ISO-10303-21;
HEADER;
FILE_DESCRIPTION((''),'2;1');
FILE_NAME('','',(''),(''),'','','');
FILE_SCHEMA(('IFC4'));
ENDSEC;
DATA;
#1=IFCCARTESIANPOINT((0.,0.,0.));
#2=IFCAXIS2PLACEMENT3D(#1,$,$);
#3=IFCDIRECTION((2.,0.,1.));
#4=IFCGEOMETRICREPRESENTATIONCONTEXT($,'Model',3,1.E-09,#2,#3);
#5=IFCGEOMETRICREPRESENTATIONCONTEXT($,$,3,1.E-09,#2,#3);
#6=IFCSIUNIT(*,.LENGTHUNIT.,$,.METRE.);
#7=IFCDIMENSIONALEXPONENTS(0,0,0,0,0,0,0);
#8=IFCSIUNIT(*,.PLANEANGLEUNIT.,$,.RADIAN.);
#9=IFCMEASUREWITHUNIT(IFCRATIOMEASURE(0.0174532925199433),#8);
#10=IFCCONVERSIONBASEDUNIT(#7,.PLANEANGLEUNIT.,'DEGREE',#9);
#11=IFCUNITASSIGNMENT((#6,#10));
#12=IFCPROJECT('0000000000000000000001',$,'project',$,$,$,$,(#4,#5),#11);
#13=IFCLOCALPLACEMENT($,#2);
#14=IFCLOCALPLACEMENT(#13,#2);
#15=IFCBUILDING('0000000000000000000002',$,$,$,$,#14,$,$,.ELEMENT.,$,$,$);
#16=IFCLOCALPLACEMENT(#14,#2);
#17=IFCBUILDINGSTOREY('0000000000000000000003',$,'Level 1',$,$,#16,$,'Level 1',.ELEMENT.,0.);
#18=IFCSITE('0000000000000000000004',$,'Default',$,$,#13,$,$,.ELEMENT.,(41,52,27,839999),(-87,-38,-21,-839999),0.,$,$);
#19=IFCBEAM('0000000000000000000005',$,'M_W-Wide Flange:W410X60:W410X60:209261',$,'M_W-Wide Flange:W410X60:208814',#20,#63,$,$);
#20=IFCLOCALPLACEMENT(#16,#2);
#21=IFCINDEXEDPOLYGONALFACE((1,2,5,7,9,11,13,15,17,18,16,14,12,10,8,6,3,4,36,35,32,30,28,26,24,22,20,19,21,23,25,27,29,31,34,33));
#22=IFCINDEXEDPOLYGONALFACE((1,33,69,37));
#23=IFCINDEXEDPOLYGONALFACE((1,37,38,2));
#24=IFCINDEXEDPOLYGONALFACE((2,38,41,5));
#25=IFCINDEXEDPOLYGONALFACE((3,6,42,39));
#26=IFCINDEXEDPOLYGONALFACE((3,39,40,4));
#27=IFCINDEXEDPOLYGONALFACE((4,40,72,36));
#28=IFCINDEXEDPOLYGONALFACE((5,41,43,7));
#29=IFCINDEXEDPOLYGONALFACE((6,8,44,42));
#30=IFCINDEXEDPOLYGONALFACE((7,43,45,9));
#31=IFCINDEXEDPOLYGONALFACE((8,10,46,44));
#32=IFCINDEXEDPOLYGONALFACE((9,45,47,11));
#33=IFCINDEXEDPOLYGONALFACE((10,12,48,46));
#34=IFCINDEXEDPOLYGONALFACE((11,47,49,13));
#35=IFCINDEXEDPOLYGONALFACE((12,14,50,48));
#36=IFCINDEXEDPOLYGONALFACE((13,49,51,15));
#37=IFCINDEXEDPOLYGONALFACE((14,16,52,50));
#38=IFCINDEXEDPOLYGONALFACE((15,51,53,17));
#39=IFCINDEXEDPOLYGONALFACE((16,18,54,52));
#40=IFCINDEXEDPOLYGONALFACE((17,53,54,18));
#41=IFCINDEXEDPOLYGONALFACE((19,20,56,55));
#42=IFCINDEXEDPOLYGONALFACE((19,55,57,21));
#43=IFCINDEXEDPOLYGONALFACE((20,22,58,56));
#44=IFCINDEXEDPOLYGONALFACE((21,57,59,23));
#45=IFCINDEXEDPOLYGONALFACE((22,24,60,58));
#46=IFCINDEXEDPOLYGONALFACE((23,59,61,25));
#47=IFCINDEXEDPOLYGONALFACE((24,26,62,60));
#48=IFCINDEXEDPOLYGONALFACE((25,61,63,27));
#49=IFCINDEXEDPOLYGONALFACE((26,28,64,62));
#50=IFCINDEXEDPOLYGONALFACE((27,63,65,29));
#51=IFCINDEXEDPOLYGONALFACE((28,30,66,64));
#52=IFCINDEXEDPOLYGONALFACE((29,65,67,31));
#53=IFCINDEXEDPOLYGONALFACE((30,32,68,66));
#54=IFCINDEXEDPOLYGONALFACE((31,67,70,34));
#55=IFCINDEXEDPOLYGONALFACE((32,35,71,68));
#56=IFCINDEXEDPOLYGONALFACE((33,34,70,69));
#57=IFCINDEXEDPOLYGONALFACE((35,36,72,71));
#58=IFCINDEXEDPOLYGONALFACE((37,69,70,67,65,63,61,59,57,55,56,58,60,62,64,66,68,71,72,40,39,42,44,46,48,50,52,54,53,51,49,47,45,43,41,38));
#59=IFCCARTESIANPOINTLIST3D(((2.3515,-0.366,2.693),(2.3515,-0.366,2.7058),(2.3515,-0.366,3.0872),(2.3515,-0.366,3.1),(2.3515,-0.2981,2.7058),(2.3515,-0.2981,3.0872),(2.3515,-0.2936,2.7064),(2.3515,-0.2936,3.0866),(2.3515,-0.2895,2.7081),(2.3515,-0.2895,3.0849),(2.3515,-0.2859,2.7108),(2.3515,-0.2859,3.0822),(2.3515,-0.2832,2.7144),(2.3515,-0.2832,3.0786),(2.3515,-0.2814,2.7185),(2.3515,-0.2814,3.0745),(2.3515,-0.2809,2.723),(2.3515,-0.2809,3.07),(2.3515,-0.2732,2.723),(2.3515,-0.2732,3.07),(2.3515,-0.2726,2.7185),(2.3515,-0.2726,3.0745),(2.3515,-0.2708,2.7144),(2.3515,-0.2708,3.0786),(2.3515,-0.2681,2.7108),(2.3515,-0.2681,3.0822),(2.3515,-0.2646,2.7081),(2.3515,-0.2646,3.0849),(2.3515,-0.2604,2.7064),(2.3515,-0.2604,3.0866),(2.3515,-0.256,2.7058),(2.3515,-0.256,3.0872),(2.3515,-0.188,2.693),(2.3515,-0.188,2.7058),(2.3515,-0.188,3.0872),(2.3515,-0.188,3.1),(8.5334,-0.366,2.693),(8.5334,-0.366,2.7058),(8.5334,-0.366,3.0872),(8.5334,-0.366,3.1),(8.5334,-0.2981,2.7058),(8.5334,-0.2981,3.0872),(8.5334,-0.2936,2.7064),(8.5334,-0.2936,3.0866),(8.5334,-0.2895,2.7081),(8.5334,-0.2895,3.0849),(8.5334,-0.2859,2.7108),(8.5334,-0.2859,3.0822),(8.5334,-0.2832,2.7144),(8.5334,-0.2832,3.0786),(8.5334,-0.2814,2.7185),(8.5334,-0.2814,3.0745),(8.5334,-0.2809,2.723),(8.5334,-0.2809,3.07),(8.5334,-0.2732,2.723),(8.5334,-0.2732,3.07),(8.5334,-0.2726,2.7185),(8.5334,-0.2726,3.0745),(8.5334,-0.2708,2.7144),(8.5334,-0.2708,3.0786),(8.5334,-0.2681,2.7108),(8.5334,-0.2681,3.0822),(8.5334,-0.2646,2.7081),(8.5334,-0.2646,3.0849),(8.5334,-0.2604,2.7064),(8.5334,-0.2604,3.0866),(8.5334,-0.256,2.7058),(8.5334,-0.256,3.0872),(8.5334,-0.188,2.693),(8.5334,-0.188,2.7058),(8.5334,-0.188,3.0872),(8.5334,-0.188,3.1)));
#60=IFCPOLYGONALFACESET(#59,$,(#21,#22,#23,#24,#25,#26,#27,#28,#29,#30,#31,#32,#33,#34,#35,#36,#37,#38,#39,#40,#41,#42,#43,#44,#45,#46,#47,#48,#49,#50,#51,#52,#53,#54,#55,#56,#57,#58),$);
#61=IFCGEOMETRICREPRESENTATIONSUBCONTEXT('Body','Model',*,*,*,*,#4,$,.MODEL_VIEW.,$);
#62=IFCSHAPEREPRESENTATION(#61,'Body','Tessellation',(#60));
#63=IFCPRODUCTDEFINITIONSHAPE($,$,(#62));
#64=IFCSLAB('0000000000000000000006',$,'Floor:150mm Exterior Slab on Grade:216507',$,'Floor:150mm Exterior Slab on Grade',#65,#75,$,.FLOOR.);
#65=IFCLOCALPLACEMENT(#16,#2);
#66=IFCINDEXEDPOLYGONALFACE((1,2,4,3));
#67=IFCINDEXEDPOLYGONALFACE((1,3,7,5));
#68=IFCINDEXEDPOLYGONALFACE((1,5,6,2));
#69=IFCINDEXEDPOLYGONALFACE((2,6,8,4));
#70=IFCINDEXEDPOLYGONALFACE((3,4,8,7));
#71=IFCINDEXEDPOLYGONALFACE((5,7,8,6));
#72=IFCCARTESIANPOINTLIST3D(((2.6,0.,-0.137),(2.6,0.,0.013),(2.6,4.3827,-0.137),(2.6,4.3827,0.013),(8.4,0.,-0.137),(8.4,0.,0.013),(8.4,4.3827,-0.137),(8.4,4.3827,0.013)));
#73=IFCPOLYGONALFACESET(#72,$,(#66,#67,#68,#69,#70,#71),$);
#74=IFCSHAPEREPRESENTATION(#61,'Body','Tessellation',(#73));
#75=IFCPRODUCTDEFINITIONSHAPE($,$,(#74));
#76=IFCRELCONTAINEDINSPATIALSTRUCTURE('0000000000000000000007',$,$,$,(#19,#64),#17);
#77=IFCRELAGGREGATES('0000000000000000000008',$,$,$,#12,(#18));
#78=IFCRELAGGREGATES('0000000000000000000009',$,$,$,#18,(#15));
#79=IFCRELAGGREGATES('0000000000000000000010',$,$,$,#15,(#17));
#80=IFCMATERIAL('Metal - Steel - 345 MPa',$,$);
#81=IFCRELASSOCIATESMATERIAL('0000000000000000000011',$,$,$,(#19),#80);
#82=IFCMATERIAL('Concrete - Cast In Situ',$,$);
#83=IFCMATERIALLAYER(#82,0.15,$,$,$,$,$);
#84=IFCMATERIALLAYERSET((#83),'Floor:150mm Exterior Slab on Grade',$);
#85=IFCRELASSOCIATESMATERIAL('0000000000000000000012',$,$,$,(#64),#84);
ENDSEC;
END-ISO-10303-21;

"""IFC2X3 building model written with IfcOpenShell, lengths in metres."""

from ifc_helpers import new_model, entity, si_unit, converted_unit, direction, frame, frame_2d, origin, place, context, subcontext, project, spatial, rectangle, i_section, extrude, material, layer, layer_set, layer_usage, element, save


model = new_model("IFC2X3")

# Units and contexts
model_context = context("Model", 3, precision=1e-09, world=origin(), true_north=direction((2.0, 0.0, 1.0)))
context_of_model = context(None, 3, precision=1e-09, world=origin(), true_north=direction((2.0, 0.0, 1.0)))
body_context = subcontext(model_context, "Body", "Model", "MODEL_VIEW")
ifc_project = project(units=[si_unit("LENGTHUNIT", "METRE"), converted_unit("PLANEANGLEUNIT", "DEGREE", entity("IfcRatioMeasure", 0.0174532925199433), si_unit("PLANEANGLEUNIT", "RADIAN"), dimensions=[0, 0, 0, 0, 0, 0, 0])], contexts=[model_context, context_of_model])

# Site, building, storey
site_placement = place(None, origin())
site = spatial("IfcSite", under=ifc_project, at=site_placement, Name="Default", CompositionType="ELEMENT", RefLatitude=(41, 52, 27, 839999), RefLongitude=(-87, -38, -21, -839999), RefElevation=0.0)
building_placement = place(site_placement, origin())
building = spatial("IfcBuilding", under=site, at=building_placement, CompositionType="ELEMENT")
storey_placement = place(building_placement, origin())
storey = spatial("IfcBuildingStorey", under=building, at=storey_placement, Name="Level 1", LongName="Level 1", CompositionType="ELEMENT", Elevation=0.0)

# Beam
ifc_material_1 = material(Name="Metal - Steel - 345 MPa")
beam_placement = place(storey_placement, frame((8.5915, -0.277, 3.1), z_axis=(0.0, 0.0, 1.0), x_axis=(-1.0, 0.0, 0.0)))
element("IfcBeam", 1, at=beam_placement, inside=storey, material=ifc_material_1, Name="M_W-Wide Flange:W410X60:W410X60:209261", ObjectType="M_W-Wide Flange:W410X60:208814", context=body_context, shape_type="SweptSolid", body=[
    extrude(i_section(OverallWidth=0.178, OverallDepth=0.407, WebThickness=0.0077, FlangeThickness=0.0128, FilletRadius=0.0172, at=frame_2d((0.0, 0.0), x_axis=(1.0, 0.0))), frame((0.0581, 0.0, -0.2035), z_axis=(-1.0, 0.0, 0.0), x_axis=(0.0, -1.0, 0.0)), (0.0, 0.0, -1.0), 6.1819),
])

# Slab
ifc_material_2 = material(Name="Concrete - Cast In Situ")
ifc_layer_1 = layer(ifc_material_2, 0.15)
ifc_layer_set_1 = layer_set([ifc_layer_1], Name="Floor:150mm Exterior Slab on Grade")
ifc_layer_usage_1 = layer_usage(ifc_layer_set_1, "AXIS3", "POSITIVE", 0.0)
slab_placement = place(storey_placement, frame((2.6, 0.0, -0.137)))
element("IfcSlab", 2, at=slab_placement, inside=storey, material=ifc_layer_usage_1, Name="Floor:150mm Exterior Slab on Grade:216507", ObjectType="Floor:150mm Exterior Slab on Grade", PredefinedType="FLOOR", context=body_context, shape_type="SweptSolid", body=[
    extrude(rectangle(XDim=5.8, YDim=4.3827, at=frame_2d((0.0, 0.0), x_axis=(-1.0, 0.0))), frame((2.9, 2.1914, 0.15), z_axis=(0.0, 0.0, -1.0), x_axis=(-1.0, 0.0, 0.0)), (0.0, 0.0, 1.0), 0.15),
])

save(model, "model.ifc")
